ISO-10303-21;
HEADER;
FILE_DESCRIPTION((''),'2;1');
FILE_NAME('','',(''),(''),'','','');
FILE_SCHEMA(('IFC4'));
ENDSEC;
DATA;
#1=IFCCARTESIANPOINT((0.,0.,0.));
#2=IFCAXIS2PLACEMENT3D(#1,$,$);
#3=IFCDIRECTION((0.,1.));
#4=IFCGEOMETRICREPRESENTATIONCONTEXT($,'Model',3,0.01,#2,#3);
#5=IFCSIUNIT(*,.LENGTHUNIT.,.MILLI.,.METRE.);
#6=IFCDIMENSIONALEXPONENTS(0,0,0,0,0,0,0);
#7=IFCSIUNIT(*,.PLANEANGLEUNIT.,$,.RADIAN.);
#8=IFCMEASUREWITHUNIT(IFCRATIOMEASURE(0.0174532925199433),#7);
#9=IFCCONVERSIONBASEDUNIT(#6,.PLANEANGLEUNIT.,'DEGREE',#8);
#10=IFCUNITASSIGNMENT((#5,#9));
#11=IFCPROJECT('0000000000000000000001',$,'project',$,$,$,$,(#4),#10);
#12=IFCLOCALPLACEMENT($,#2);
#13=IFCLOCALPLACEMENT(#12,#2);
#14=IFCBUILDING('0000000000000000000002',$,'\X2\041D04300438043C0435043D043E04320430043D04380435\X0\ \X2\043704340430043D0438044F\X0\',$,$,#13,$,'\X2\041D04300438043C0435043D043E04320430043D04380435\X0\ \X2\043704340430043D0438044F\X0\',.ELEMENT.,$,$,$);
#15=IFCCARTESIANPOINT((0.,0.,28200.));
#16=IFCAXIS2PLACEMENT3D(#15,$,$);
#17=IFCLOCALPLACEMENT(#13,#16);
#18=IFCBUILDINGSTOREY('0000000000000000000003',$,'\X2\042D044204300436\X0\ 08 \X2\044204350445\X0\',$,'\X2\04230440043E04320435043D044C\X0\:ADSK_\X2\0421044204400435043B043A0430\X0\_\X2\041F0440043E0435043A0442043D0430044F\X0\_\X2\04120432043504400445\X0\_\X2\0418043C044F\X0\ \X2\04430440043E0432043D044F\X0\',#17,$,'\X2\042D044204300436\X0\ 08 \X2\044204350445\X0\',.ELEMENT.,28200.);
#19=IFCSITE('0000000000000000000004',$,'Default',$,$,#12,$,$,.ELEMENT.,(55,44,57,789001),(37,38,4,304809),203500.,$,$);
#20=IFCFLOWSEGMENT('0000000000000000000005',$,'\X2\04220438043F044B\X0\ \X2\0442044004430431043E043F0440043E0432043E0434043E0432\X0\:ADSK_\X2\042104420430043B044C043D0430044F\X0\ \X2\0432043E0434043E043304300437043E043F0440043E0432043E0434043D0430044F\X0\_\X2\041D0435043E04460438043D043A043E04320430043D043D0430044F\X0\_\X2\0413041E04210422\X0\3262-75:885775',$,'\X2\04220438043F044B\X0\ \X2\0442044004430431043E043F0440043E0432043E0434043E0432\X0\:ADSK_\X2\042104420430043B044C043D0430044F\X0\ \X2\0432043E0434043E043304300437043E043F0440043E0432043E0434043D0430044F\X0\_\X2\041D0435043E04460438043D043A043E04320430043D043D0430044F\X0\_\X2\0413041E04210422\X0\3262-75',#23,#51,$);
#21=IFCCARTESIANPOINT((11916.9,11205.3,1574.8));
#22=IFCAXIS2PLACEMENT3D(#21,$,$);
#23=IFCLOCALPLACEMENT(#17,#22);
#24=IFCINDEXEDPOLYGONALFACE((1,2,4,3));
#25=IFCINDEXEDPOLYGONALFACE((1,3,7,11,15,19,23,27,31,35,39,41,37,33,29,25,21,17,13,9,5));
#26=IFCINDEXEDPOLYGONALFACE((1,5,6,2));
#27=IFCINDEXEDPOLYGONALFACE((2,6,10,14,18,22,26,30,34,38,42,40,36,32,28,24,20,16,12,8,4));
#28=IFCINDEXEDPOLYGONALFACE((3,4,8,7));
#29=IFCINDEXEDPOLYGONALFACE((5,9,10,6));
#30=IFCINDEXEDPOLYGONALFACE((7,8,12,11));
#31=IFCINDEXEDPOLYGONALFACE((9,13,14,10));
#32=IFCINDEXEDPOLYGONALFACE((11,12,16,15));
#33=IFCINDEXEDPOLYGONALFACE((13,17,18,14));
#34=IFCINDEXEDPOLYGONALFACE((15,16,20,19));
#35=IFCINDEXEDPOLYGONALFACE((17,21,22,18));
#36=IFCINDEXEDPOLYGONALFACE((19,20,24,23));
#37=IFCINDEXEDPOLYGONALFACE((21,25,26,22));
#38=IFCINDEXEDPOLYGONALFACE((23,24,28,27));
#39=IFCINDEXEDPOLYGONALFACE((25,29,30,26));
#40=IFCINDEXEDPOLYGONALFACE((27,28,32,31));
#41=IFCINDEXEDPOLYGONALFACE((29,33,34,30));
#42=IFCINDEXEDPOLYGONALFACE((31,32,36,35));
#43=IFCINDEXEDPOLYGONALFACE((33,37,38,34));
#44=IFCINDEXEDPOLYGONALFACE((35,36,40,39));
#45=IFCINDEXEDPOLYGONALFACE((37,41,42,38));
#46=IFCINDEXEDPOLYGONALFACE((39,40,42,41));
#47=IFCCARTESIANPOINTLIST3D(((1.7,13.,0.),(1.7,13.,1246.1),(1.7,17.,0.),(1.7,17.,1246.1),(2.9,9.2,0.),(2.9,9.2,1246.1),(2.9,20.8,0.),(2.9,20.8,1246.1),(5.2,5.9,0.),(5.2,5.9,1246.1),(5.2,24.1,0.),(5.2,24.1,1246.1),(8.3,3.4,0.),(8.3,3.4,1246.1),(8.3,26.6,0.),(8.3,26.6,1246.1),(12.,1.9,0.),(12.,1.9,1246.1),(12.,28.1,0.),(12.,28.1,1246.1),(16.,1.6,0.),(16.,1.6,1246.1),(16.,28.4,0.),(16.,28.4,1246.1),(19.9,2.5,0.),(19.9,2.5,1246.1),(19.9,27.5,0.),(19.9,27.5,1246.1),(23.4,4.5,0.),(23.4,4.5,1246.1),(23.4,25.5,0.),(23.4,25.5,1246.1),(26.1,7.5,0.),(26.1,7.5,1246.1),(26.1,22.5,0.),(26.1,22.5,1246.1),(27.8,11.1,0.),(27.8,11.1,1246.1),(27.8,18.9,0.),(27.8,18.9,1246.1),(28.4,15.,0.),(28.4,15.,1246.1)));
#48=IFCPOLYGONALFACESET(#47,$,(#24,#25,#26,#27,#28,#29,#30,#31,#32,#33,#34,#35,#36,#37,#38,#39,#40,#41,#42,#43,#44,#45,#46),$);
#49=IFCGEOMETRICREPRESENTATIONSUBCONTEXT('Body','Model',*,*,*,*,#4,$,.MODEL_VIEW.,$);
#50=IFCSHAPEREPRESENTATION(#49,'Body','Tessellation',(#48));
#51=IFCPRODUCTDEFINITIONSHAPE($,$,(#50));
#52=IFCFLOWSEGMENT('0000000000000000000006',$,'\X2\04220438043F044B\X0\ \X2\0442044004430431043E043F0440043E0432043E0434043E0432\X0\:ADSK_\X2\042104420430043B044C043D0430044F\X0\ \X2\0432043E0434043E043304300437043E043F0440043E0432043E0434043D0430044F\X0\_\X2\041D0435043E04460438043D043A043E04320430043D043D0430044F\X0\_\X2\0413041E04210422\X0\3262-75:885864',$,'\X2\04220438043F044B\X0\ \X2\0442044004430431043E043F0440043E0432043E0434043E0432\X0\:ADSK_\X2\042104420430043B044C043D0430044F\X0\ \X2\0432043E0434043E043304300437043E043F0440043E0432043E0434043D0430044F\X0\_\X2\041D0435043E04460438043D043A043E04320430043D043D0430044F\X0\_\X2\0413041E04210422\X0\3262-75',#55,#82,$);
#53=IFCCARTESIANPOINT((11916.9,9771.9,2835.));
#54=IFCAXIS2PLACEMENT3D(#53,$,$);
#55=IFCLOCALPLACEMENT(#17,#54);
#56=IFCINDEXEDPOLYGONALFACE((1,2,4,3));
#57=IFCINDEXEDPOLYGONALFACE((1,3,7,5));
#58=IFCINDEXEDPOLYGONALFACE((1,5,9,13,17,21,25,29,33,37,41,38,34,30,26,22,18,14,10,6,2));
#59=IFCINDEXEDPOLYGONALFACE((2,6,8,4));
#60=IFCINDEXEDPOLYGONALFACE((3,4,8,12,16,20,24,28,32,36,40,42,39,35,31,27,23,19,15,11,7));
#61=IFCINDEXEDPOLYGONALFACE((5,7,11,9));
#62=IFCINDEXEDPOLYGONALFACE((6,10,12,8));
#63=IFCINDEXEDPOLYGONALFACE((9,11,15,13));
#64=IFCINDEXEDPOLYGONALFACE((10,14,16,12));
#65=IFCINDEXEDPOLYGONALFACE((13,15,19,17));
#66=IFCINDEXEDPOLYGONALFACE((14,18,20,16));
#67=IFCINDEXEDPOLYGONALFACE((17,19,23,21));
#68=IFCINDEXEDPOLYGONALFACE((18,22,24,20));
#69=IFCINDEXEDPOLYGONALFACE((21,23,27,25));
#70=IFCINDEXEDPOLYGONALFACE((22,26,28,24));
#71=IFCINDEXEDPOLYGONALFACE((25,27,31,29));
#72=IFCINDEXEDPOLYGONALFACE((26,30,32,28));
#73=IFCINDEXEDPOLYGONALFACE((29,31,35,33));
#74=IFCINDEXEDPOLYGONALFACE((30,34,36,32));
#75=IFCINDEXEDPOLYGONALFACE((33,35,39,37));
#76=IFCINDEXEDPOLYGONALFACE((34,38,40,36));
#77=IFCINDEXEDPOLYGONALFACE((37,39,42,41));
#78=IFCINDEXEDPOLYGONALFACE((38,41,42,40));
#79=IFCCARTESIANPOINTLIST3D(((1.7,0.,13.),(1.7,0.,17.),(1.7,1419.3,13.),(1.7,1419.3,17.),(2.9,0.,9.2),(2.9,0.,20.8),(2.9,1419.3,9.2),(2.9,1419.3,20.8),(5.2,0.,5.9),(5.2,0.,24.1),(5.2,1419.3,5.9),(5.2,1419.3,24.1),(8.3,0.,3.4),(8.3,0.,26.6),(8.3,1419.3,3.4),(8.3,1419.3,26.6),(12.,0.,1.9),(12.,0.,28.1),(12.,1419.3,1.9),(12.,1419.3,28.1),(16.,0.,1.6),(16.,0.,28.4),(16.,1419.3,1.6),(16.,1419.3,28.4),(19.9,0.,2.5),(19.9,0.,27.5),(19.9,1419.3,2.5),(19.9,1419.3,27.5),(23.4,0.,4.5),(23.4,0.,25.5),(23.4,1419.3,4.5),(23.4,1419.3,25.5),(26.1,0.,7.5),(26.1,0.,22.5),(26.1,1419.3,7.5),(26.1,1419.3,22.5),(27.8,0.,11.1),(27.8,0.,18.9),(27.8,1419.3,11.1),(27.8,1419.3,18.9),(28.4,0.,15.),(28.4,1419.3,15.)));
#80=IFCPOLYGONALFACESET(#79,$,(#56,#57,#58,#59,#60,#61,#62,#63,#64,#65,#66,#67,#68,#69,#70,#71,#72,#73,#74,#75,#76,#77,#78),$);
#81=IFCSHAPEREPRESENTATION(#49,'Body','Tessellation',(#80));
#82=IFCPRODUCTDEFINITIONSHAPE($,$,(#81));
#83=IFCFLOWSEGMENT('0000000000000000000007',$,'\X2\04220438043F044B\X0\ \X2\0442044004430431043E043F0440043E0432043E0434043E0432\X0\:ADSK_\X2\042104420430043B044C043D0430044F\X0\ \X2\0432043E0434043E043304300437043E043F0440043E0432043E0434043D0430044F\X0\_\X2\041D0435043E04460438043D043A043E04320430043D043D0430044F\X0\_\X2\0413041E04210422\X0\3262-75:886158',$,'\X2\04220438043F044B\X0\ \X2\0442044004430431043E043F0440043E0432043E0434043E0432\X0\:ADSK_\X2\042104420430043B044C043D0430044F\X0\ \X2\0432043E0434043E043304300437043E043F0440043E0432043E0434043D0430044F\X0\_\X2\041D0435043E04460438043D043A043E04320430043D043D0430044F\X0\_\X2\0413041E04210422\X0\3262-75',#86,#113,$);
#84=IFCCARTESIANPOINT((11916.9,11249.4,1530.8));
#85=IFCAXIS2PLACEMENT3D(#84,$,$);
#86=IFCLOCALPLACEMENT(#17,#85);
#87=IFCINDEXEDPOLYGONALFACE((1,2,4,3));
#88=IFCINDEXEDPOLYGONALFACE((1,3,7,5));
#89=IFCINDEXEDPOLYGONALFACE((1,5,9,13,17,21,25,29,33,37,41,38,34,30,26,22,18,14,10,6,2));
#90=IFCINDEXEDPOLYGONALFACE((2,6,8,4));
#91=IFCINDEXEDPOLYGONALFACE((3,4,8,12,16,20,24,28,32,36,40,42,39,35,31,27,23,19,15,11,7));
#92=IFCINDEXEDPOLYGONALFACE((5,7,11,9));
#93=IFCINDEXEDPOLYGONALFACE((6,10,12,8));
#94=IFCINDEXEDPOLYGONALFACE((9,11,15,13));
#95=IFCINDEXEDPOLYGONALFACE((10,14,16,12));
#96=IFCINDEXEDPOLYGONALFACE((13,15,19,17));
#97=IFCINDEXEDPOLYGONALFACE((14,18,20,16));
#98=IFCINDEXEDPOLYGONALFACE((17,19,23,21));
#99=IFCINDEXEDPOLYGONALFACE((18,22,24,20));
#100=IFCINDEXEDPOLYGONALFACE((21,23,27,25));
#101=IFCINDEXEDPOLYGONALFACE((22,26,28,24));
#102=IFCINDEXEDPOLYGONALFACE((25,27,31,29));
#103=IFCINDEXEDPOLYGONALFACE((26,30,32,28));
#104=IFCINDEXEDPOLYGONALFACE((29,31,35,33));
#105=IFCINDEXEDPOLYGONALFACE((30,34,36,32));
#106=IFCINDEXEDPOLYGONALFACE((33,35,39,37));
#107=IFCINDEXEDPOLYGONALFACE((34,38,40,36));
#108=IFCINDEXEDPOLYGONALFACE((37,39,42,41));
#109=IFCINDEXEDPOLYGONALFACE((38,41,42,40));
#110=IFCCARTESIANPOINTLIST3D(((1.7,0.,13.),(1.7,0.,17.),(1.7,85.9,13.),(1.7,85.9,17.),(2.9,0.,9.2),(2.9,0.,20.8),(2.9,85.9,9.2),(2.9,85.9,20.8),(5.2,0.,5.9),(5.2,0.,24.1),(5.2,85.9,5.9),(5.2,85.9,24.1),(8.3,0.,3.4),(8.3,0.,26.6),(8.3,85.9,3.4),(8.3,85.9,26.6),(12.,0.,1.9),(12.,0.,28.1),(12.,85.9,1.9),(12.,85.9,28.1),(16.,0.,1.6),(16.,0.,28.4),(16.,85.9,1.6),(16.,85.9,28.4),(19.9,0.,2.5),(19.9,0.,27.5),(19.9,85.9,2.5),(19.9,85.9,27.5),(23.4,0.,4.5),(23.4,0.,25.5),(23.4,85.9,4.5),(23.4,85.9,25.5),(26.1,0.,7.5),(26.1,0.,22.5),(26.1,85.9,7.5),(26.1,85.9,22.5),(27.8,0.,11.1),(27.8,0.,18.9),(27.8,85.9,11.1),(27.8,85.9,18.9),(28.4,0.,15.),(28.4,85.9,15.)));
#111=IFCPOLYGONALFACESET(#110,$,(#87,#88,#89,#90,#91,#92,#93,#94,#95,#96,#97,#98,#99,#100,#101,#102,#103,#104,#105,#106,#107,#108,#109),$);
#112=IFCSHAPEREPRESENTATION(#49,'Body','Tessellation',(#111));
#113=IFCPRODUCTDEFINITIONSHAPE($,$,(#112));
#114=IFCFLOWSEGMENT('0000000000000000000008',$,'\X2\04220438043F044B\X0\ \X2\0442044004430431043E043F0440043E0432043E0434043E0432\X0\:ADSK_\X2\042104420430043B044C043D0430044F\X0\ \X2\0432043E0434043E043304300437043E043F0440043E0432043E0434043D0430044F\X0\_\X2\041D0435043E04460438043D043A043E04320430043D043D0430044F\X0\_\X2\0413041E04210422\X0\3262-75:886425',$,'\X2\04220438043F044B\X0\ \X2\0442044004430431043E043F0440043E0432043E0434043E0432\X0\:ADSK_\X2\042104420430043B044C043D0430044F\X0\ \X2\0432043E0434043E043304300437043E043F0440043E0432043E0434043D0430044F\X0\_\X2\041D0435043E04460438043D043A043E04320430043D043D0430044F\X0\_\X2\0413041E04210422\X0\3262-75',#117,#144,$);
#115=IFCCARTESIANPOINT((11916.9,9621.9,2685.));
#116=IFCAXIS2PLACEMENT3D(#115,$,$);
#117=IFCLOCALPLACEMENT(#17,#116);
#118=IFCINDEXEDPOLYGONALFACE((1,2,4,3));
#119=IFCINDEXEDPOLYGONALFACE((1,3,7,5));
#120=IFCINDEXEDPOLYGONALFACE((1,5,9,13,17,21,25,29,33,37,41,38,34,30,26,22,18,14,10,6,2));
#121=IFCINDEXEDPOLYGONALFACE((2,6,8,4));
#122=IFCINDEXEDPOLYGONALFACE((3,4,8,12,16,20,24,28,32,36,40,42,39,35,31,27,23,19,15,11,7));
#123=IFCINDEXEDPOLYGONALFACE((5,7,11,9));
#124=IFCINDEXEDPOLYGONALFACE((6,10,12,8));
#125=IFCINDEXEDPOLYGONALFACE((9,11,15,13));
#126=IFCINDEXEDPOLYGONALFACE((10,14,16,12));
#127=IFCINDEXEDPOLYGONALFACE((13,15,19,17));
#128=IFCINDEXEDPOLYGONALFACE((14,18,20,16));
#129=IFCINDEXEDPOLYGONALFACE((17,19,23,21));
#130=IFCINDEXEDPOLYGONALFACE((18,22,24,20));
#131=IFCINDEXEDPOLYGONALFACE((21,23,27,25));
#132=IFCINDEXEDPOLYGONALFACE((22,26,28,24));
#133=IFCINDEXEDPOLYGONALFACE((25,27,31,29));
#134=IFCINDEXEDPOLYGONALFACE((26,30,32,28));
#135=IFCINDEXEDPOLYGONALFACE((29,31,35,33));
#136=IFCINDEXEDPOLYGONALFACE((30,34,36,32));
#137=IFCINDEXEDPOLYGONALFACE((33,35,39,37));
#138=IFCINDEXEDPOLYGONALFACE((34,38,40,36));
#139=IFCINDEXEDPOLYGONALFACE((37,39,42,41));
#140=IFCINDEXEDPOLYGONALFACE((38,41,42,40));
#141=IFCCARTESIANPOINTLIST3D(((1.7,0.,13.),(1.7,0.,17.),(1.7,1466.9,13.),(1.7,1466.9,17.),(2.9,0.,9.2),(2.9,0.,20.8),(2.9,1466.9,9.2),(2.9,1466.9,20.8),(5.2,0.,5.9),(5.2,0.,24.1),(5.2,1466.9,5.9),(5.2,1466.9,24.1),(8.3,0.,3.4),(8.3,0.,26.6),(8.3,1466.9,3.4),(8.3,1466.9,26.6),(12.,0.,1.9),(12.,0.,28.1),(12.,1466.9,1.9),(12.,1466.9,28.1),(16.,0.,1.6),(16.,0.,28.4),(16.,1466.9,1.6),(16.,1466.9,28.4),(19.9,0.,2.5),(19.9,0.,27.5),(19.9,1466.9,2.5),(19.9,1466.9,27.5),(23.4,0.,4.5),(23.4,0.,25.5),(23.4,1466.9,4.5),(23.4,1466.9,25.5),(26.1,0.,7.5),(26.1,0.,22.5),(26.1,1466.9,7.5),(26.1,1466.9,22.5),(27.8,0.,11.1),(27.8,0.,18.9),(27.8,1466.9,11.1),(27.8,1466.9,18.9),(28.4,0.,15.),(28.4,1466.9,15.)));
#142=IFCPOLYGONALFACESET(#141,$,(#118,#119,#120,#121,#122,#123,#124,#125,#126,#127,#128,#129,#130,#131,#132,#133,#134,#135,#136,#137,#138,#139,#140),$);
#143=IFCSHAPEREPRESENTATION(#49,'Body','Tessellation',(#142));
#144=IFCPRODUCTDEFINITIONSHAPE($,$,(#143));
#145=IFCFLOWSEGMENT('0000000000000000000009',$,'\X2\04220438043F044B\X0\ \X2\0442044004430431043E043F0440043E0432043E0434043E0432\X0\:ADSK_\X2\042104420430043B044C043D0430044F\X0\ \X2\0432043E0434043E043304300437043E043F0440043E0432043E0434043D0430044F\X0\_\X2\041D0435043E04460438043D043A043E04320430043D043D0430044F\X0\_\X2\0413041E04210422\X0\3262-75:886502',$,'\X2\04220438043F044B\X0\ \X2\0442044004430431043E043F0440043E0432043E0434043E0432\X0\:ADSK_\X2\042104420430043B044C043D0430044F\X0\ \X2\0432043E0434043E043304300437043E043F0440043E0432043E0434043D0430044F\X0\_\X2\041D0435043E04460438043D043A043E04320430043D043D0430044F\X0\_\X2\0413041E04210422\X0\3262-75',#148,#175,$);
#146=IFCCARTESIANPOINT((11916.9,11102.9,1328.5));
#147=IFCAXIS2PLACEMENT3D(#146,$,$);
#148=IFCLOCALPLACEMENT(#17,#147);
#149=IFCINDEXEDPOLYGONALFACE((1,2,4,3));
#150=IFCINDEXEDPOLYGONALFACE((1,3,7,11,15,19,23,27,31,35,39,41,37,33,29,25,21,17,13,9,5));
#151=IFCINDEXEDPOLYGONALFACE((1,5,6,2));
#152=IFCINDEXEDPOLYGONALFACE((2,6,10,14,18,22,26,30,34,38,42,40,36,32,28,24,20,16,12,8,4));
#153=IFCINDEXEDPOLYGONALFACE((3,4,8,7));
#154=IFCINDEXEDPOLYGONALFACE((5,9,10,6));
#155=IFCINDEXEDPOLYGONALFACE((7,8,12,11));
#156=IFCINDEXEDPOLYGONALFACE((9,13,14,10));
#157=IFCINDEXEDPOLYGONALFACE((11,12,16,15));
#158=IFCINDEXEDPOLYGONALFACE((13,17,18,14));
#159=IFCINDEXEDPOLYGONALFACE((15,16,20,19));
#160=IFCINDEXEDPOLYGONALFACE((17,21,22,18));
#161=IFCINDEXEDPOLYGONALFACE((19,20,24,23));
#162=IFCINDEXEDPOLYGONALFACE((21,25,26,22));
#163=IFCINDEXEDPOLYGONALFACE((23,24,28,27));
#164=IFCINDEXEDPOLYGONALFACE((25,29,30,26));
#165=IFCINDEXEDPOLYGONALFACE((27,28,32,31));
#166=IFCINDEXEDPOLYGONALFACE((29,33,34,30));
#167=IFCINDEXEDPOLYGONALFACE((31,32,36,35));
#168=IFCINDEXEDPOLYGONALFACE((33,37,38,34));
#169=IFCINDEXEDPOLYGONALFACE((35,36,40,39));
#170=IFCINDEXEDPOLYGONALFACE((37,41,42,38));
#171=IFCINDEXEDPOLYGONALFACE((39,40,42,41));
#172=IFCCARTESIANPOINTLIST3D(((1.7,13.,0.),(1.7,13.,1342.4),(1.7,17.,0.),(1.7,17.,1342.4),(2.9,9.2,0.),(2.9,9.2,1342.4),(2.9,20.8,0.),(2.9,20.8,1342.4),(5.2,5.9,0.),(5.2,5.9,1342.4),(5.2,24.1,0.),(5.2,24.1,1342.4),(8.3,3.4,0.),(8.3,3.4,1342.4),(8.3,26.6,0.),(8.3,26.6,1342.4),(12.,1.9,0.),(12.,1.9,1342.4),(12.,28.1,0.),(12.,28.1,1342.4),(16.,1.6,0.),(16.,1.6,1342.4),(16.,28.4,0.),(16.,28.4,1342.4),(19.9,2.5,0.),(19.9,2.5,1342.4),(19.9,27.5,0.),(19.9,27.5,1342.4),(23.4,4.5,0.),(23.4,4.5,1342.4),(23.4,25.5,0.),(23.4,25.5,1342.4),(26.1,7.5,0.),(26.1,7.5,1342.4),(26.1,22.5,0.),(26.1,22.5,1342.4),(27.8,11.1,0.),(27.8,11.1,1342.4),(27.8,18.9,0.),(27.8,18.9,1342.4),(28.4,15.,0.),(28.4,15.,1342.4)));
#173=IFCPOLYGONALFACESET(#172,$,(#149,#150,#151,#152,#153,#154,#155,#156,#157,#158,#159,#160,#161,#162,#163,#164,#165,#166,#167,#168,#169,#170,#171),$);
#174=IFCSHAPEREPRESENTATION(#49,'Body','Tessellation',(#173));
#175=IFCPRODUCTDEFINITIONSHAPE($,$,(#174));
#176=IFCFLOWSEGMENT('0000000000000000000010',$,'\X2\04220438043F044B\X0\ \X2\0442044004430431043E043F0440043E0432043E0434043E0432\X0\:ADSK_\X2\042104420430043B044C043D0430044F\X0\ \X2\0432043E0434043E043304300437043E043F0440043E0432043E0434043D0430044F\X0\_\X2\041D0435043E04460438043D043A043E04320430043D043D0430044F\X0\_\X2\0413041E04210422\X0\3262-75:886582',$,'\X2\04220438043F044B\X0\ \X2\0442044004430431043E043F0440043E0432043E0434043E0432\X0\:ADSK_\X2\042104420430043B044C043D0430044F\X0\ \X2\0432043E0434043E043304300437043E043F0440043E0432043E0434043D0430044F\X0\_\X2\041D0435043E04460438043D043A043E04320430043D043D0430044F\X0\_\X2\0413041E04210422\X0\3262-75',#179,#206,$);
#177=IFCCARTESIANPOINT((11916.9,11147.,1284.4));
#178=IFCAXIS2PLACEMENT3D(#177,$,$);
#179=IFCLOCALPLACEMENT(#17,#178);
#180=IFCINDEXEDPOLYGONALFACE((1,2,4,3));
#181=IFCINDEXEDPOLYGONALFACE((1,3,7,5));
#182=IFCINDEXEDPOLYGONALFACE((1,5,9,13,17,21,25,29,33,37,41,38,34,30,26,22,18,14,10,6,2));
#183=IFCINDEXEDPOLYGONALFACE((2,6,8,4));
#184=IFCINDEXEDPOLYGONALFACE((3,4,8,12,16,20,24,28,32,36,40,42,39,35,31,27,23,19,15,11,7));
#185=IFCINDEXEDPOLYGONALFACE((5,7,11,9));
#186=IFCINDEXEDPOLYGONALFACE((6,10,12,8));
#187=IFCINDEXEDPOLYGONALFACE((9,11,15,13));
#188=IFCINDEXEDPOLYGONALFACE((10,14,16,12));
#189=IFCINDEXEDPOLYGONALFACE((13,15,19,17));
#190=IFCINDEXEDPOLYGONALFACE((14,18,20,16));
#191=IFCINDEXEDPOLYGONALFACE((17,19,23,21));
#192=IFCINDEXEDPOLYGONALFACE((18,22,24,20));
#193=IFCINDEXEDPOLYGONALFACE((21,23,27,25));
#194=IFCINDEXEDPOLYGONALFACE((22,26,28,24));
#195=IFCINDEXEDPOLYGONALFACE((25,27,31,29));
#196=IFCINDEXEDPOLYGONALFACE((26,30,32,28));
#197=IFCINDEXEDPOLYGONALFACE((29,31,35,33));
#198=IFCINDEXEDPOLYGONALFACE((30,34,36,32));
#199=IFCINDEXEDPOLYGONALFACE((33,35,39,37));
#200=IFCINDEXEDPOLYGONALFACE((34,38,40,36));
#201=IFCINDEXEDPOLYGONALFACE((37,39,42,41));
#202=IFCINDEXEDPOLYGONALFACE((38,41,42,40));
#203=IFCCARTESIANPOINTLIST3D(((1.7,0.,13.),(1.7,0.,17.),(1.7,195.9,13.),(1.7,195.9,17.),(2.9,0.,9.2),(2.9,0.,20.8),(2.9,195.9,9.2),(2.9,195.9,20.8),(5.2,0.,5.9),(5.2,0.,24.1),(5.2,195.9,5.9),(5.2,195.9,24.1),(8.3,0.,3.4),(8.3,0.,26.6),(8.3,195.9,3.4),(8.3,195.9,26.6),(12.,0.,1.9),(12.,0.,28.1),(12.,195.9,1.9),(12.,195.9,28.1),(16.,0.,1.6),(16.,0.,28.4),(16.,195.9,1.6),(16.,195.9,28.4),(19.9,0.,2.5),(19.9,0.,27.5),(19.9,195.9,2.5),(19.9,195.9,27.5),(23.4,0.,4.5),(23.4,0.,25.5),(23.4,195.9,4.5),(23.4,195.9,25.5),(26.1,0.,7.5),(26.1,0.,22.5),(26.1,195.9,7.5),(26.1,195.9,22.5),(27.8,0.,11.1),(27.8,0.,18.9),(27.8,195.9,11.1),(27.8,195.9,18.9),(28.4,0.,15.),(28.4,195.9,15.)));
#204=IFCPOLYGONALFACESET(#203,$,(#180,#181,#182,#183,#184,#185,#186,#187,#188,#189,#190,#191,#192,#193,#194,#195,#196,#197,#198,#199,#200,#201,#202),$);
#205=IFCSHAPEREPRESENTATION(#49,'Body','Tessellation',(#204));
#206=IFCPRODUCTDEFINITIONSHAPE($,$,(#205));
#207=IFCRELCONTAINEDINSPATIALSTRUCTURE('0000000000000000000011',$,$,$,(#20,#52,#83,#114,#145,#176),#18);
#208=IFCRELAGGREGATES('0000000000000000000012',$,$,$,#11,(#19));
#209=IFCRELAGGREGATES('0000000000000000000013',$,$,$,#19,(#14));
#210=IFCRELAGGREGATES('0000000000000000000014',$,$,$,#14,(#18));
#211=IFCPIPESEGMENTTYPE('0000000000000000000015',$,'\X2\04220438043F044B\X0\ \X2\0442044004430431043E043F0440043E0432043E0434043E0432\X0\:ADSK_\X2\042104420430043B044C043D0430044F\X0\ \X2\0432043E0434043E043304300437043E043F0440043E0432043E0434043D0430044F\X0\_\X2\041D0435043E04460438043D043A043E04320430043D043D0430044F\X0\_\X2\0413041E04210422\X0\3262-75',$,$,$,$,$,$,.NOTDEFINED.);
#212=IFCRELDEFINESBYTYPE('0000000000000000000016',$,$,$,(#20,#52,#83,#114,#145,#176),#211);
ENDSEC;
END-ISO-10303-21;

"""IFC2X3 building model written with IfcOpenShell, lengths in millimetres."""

from ifc_helpers import new_model, entity, si_unit, converted_unit, direction, frame, origin, origin_2d_with_axis, place, context, subcontext, project, spatial, circle, extrude, type_object, element, save


model = new_model("IFC2X3")

# Units and contexts
model_context = context("Model", 3, precision=0.01, world=origin(), true_north=direction((0.0, 1.0)))
body_context = subcontext(model_context, "Body", "Model", "MODEL_VIEW")
ifc_project = project(units=[si_unit("LENGTHUNIT", "METRE", prefix="MILLI"), converted_unit("PLANEANGLEUNIT", "DEGREE", entity("IfcRatioMeasure", 0.0174532925199433), si_unit("PLANEANGLEUNIT", "RADIAN"), dimensions=[0, 0, 0, 0, 0, 0, 0])], contexts=[model_context])

# Site, building, storey
site_placement = place(None, origin())
site = spatial("IfcSite", under=ifc_project, at=site_placement, Name="Default", CompositionType="ELEMENT", RefLatitude=(55, 44, 57, 789001), RefLongitude=(37, 38, 4, 304809), RefElevation=203500.0)
building_placement = place(site_placement, origin())
building = spatial("IfcBuilding", under=site, at=building_placement, Name="Наименование здания", LongName="Наименование здания", CompositionType="ELEMENT")
storey_placement = place(building_placement, frame((0.0, 0.0, 28200.0)))
storey = spatial("IfcBuildingStorey", under=building, at=storey_placement, Name="Этаж 08 тех", ObjectType="Уровень:ADSK_Стрелка_Проектная_Вверх_Имя уровня", LongName="Этаж 08 тех", CompositionType="ELEMENT", Elevation=28200.0)

# Flow segments
pipe_segment_type = type_object("IfcPipeSegmentType", Name="Типы трубопроводов:ADSK_Стальная водогазопроводная_Неоцинкованная_ГОСТ3262-75", PredefinedType="NOTDEFINED")
flow_segment_1_placement = place(storey_placement, frame((11916.9, 11205.3, 1574.8)))
element("IfcFlowSegment", 1, at=flow_segment_1_placement, inside=storey, type_object=pipe_segment_type, Name="Типы трубопроводов:ADSK_Стальная водогазопроводная_Неоцинкованная_ГОСТ3262-75:885775", ObjectType="Типы трубопроводов:ADSK_Стальная водогазопроводная_Неоцинкованная_ГОСТ3262-75", context=body_context, shape_type="SweptSolid", body=[
    extrude(circle(Radius=13.4, at=origin_2d_with_axis()), frame((15.0, 15.0, 0.0)), (0.0, 0.0, 1.0), 1246.1),
])
flow_segment_2_placement = place(storey_placement, frame((11916.9, 9771.9, 2835.0)))
element("IfcFlowSegment", 2, at=flow_segment_2_placement, inside=storey, type_object=pipe_segment_type, Name="Типы трубопроводов:ADSK_Стальная водогазопроводная_Неоцинкованная_ГОСТ3262-75:885864", ObjectType="Типы трубопроводов:ADSK_Стальная водогазопроводная_Неоцинкованная_ГОСТ3262-75", context=body_context, shape_type="SweptSolid", body=[
    extrude(circle(Radius=13.4, at=origin_2d_with_axis()), frame((15.0, 0.0, 15.0), z_axis=(0.0, 1.0, 0.0), x_axis=(1.0, 0.0, 0.0)), (0.0, 0.0, 1.0), 1419.3),
])
flow_segment_3_placement = place(storey_placement, frame((11916.9, 11249.4, 1530.8)))
element("IfcFlowSegment", 3, at=flow_segment_3_placement, inside=storey, type_object=pipe_segment_type, Name="Типы трубопроводов:ADSK_Стальная водогазопроводная_Неоцинкованная_ГОСТ3262-75:886158", ObjectType="Типы трубопроводов:ADSK_Стальная водогазопроводная_Неоцинкованная_ГОСТ3262-75", context=body_context, shape_type="SweptSolid", body=[
    extrude(circle(Radius=13.4, at=origin_2d_with_axis()), frame((15.0, 0.0, 15.0), z_axis=(0.0, 1.0, 0.0), x_axis=(1.0, 0.0, 0.0)), (0.0, 0.0, 1.0), 85.9),
])
flow_segment_4_placement = place(storey_placement, frame((11916.9, 9621.9, 2685.0)))
element("IfcFlowSegment", 4, at=flow_segment_4_placement, inside=storey, type_object=pipe_segment_type, Name="Типы трубопроводов:ADSK_Стальная водогазопроводная_Неоцинкованная_ГОСТ3262-75:886425", ObjectType="Типы трубопроводов:ADSK_Стальная водогазопроводная_Неоцинкованная_ГОСТ3262-75", context=body_context, shape_type="SweptSolid", body=[
    extrude(circle(Radius=13.4, at=origin_2d_with_axis()), frame((15.0, 0.0, 15.0), z_axis=(0.0, 1.0, 0.0), x_axis=(1.0, 0.0, 0.0)), (0.0, 0.0, 1.0), 1466.9),
])
flow_segment_5_placement = place(storey_placement, frame((11916.9, 11102.9, 1328.5)))
element("IfcFlowSegment", 5, at=flow_segment_5_placement, inside=storey, type_object=pipe_segment_type, Name="Типы трубопроводов:ADSK_Стальная водогазопроводная_Неоцинкованная_ГОСТ3262-75:886502", ObjectType="Типы трубопроводов:ADSK_Стальная водогазопроводная_Неоцинкованная_ГОСТ3262-75", context=body_context, shape_type="SweptSolid", body=[
    extrude(circle(Radius=13.4, at=origin_2d_with_axis()), frame((15.0, 15.0, 0.0)), (0.0, 0.0, 1.0), 1342.4),
])
flow_segment_6_placement = place(storey_placement, frame((11916.9, 11147.0, 1284.4)))
element("IfcFlowSegment", 6, at=flow_segment_6_placement, inside=storey, type_object=pipe_segment_type, Name="Типы трубопроводов:ADSK_Стальная водогазопроводная_Неоцинкованная_ГОСТ3262-75:886582", ObjectType="Типы трубопроводов:ADSK_Стальная водогазопроводная_Неоцинкованная_ГОСТ3262-75", context=body_context, shape_type="SweptSolid", body=[
    extrude(circle(Radius=13.4, at=origin_2d_with_axis()), frame((15.0, 0.0, 15.0), z_axis=(0.0, 1.0, 0.0), x_axis=(1.0, 0.0, 0.0)), (0.0, 0.0, 1.0), 195.9),
])

save(model, "model.ifc")
